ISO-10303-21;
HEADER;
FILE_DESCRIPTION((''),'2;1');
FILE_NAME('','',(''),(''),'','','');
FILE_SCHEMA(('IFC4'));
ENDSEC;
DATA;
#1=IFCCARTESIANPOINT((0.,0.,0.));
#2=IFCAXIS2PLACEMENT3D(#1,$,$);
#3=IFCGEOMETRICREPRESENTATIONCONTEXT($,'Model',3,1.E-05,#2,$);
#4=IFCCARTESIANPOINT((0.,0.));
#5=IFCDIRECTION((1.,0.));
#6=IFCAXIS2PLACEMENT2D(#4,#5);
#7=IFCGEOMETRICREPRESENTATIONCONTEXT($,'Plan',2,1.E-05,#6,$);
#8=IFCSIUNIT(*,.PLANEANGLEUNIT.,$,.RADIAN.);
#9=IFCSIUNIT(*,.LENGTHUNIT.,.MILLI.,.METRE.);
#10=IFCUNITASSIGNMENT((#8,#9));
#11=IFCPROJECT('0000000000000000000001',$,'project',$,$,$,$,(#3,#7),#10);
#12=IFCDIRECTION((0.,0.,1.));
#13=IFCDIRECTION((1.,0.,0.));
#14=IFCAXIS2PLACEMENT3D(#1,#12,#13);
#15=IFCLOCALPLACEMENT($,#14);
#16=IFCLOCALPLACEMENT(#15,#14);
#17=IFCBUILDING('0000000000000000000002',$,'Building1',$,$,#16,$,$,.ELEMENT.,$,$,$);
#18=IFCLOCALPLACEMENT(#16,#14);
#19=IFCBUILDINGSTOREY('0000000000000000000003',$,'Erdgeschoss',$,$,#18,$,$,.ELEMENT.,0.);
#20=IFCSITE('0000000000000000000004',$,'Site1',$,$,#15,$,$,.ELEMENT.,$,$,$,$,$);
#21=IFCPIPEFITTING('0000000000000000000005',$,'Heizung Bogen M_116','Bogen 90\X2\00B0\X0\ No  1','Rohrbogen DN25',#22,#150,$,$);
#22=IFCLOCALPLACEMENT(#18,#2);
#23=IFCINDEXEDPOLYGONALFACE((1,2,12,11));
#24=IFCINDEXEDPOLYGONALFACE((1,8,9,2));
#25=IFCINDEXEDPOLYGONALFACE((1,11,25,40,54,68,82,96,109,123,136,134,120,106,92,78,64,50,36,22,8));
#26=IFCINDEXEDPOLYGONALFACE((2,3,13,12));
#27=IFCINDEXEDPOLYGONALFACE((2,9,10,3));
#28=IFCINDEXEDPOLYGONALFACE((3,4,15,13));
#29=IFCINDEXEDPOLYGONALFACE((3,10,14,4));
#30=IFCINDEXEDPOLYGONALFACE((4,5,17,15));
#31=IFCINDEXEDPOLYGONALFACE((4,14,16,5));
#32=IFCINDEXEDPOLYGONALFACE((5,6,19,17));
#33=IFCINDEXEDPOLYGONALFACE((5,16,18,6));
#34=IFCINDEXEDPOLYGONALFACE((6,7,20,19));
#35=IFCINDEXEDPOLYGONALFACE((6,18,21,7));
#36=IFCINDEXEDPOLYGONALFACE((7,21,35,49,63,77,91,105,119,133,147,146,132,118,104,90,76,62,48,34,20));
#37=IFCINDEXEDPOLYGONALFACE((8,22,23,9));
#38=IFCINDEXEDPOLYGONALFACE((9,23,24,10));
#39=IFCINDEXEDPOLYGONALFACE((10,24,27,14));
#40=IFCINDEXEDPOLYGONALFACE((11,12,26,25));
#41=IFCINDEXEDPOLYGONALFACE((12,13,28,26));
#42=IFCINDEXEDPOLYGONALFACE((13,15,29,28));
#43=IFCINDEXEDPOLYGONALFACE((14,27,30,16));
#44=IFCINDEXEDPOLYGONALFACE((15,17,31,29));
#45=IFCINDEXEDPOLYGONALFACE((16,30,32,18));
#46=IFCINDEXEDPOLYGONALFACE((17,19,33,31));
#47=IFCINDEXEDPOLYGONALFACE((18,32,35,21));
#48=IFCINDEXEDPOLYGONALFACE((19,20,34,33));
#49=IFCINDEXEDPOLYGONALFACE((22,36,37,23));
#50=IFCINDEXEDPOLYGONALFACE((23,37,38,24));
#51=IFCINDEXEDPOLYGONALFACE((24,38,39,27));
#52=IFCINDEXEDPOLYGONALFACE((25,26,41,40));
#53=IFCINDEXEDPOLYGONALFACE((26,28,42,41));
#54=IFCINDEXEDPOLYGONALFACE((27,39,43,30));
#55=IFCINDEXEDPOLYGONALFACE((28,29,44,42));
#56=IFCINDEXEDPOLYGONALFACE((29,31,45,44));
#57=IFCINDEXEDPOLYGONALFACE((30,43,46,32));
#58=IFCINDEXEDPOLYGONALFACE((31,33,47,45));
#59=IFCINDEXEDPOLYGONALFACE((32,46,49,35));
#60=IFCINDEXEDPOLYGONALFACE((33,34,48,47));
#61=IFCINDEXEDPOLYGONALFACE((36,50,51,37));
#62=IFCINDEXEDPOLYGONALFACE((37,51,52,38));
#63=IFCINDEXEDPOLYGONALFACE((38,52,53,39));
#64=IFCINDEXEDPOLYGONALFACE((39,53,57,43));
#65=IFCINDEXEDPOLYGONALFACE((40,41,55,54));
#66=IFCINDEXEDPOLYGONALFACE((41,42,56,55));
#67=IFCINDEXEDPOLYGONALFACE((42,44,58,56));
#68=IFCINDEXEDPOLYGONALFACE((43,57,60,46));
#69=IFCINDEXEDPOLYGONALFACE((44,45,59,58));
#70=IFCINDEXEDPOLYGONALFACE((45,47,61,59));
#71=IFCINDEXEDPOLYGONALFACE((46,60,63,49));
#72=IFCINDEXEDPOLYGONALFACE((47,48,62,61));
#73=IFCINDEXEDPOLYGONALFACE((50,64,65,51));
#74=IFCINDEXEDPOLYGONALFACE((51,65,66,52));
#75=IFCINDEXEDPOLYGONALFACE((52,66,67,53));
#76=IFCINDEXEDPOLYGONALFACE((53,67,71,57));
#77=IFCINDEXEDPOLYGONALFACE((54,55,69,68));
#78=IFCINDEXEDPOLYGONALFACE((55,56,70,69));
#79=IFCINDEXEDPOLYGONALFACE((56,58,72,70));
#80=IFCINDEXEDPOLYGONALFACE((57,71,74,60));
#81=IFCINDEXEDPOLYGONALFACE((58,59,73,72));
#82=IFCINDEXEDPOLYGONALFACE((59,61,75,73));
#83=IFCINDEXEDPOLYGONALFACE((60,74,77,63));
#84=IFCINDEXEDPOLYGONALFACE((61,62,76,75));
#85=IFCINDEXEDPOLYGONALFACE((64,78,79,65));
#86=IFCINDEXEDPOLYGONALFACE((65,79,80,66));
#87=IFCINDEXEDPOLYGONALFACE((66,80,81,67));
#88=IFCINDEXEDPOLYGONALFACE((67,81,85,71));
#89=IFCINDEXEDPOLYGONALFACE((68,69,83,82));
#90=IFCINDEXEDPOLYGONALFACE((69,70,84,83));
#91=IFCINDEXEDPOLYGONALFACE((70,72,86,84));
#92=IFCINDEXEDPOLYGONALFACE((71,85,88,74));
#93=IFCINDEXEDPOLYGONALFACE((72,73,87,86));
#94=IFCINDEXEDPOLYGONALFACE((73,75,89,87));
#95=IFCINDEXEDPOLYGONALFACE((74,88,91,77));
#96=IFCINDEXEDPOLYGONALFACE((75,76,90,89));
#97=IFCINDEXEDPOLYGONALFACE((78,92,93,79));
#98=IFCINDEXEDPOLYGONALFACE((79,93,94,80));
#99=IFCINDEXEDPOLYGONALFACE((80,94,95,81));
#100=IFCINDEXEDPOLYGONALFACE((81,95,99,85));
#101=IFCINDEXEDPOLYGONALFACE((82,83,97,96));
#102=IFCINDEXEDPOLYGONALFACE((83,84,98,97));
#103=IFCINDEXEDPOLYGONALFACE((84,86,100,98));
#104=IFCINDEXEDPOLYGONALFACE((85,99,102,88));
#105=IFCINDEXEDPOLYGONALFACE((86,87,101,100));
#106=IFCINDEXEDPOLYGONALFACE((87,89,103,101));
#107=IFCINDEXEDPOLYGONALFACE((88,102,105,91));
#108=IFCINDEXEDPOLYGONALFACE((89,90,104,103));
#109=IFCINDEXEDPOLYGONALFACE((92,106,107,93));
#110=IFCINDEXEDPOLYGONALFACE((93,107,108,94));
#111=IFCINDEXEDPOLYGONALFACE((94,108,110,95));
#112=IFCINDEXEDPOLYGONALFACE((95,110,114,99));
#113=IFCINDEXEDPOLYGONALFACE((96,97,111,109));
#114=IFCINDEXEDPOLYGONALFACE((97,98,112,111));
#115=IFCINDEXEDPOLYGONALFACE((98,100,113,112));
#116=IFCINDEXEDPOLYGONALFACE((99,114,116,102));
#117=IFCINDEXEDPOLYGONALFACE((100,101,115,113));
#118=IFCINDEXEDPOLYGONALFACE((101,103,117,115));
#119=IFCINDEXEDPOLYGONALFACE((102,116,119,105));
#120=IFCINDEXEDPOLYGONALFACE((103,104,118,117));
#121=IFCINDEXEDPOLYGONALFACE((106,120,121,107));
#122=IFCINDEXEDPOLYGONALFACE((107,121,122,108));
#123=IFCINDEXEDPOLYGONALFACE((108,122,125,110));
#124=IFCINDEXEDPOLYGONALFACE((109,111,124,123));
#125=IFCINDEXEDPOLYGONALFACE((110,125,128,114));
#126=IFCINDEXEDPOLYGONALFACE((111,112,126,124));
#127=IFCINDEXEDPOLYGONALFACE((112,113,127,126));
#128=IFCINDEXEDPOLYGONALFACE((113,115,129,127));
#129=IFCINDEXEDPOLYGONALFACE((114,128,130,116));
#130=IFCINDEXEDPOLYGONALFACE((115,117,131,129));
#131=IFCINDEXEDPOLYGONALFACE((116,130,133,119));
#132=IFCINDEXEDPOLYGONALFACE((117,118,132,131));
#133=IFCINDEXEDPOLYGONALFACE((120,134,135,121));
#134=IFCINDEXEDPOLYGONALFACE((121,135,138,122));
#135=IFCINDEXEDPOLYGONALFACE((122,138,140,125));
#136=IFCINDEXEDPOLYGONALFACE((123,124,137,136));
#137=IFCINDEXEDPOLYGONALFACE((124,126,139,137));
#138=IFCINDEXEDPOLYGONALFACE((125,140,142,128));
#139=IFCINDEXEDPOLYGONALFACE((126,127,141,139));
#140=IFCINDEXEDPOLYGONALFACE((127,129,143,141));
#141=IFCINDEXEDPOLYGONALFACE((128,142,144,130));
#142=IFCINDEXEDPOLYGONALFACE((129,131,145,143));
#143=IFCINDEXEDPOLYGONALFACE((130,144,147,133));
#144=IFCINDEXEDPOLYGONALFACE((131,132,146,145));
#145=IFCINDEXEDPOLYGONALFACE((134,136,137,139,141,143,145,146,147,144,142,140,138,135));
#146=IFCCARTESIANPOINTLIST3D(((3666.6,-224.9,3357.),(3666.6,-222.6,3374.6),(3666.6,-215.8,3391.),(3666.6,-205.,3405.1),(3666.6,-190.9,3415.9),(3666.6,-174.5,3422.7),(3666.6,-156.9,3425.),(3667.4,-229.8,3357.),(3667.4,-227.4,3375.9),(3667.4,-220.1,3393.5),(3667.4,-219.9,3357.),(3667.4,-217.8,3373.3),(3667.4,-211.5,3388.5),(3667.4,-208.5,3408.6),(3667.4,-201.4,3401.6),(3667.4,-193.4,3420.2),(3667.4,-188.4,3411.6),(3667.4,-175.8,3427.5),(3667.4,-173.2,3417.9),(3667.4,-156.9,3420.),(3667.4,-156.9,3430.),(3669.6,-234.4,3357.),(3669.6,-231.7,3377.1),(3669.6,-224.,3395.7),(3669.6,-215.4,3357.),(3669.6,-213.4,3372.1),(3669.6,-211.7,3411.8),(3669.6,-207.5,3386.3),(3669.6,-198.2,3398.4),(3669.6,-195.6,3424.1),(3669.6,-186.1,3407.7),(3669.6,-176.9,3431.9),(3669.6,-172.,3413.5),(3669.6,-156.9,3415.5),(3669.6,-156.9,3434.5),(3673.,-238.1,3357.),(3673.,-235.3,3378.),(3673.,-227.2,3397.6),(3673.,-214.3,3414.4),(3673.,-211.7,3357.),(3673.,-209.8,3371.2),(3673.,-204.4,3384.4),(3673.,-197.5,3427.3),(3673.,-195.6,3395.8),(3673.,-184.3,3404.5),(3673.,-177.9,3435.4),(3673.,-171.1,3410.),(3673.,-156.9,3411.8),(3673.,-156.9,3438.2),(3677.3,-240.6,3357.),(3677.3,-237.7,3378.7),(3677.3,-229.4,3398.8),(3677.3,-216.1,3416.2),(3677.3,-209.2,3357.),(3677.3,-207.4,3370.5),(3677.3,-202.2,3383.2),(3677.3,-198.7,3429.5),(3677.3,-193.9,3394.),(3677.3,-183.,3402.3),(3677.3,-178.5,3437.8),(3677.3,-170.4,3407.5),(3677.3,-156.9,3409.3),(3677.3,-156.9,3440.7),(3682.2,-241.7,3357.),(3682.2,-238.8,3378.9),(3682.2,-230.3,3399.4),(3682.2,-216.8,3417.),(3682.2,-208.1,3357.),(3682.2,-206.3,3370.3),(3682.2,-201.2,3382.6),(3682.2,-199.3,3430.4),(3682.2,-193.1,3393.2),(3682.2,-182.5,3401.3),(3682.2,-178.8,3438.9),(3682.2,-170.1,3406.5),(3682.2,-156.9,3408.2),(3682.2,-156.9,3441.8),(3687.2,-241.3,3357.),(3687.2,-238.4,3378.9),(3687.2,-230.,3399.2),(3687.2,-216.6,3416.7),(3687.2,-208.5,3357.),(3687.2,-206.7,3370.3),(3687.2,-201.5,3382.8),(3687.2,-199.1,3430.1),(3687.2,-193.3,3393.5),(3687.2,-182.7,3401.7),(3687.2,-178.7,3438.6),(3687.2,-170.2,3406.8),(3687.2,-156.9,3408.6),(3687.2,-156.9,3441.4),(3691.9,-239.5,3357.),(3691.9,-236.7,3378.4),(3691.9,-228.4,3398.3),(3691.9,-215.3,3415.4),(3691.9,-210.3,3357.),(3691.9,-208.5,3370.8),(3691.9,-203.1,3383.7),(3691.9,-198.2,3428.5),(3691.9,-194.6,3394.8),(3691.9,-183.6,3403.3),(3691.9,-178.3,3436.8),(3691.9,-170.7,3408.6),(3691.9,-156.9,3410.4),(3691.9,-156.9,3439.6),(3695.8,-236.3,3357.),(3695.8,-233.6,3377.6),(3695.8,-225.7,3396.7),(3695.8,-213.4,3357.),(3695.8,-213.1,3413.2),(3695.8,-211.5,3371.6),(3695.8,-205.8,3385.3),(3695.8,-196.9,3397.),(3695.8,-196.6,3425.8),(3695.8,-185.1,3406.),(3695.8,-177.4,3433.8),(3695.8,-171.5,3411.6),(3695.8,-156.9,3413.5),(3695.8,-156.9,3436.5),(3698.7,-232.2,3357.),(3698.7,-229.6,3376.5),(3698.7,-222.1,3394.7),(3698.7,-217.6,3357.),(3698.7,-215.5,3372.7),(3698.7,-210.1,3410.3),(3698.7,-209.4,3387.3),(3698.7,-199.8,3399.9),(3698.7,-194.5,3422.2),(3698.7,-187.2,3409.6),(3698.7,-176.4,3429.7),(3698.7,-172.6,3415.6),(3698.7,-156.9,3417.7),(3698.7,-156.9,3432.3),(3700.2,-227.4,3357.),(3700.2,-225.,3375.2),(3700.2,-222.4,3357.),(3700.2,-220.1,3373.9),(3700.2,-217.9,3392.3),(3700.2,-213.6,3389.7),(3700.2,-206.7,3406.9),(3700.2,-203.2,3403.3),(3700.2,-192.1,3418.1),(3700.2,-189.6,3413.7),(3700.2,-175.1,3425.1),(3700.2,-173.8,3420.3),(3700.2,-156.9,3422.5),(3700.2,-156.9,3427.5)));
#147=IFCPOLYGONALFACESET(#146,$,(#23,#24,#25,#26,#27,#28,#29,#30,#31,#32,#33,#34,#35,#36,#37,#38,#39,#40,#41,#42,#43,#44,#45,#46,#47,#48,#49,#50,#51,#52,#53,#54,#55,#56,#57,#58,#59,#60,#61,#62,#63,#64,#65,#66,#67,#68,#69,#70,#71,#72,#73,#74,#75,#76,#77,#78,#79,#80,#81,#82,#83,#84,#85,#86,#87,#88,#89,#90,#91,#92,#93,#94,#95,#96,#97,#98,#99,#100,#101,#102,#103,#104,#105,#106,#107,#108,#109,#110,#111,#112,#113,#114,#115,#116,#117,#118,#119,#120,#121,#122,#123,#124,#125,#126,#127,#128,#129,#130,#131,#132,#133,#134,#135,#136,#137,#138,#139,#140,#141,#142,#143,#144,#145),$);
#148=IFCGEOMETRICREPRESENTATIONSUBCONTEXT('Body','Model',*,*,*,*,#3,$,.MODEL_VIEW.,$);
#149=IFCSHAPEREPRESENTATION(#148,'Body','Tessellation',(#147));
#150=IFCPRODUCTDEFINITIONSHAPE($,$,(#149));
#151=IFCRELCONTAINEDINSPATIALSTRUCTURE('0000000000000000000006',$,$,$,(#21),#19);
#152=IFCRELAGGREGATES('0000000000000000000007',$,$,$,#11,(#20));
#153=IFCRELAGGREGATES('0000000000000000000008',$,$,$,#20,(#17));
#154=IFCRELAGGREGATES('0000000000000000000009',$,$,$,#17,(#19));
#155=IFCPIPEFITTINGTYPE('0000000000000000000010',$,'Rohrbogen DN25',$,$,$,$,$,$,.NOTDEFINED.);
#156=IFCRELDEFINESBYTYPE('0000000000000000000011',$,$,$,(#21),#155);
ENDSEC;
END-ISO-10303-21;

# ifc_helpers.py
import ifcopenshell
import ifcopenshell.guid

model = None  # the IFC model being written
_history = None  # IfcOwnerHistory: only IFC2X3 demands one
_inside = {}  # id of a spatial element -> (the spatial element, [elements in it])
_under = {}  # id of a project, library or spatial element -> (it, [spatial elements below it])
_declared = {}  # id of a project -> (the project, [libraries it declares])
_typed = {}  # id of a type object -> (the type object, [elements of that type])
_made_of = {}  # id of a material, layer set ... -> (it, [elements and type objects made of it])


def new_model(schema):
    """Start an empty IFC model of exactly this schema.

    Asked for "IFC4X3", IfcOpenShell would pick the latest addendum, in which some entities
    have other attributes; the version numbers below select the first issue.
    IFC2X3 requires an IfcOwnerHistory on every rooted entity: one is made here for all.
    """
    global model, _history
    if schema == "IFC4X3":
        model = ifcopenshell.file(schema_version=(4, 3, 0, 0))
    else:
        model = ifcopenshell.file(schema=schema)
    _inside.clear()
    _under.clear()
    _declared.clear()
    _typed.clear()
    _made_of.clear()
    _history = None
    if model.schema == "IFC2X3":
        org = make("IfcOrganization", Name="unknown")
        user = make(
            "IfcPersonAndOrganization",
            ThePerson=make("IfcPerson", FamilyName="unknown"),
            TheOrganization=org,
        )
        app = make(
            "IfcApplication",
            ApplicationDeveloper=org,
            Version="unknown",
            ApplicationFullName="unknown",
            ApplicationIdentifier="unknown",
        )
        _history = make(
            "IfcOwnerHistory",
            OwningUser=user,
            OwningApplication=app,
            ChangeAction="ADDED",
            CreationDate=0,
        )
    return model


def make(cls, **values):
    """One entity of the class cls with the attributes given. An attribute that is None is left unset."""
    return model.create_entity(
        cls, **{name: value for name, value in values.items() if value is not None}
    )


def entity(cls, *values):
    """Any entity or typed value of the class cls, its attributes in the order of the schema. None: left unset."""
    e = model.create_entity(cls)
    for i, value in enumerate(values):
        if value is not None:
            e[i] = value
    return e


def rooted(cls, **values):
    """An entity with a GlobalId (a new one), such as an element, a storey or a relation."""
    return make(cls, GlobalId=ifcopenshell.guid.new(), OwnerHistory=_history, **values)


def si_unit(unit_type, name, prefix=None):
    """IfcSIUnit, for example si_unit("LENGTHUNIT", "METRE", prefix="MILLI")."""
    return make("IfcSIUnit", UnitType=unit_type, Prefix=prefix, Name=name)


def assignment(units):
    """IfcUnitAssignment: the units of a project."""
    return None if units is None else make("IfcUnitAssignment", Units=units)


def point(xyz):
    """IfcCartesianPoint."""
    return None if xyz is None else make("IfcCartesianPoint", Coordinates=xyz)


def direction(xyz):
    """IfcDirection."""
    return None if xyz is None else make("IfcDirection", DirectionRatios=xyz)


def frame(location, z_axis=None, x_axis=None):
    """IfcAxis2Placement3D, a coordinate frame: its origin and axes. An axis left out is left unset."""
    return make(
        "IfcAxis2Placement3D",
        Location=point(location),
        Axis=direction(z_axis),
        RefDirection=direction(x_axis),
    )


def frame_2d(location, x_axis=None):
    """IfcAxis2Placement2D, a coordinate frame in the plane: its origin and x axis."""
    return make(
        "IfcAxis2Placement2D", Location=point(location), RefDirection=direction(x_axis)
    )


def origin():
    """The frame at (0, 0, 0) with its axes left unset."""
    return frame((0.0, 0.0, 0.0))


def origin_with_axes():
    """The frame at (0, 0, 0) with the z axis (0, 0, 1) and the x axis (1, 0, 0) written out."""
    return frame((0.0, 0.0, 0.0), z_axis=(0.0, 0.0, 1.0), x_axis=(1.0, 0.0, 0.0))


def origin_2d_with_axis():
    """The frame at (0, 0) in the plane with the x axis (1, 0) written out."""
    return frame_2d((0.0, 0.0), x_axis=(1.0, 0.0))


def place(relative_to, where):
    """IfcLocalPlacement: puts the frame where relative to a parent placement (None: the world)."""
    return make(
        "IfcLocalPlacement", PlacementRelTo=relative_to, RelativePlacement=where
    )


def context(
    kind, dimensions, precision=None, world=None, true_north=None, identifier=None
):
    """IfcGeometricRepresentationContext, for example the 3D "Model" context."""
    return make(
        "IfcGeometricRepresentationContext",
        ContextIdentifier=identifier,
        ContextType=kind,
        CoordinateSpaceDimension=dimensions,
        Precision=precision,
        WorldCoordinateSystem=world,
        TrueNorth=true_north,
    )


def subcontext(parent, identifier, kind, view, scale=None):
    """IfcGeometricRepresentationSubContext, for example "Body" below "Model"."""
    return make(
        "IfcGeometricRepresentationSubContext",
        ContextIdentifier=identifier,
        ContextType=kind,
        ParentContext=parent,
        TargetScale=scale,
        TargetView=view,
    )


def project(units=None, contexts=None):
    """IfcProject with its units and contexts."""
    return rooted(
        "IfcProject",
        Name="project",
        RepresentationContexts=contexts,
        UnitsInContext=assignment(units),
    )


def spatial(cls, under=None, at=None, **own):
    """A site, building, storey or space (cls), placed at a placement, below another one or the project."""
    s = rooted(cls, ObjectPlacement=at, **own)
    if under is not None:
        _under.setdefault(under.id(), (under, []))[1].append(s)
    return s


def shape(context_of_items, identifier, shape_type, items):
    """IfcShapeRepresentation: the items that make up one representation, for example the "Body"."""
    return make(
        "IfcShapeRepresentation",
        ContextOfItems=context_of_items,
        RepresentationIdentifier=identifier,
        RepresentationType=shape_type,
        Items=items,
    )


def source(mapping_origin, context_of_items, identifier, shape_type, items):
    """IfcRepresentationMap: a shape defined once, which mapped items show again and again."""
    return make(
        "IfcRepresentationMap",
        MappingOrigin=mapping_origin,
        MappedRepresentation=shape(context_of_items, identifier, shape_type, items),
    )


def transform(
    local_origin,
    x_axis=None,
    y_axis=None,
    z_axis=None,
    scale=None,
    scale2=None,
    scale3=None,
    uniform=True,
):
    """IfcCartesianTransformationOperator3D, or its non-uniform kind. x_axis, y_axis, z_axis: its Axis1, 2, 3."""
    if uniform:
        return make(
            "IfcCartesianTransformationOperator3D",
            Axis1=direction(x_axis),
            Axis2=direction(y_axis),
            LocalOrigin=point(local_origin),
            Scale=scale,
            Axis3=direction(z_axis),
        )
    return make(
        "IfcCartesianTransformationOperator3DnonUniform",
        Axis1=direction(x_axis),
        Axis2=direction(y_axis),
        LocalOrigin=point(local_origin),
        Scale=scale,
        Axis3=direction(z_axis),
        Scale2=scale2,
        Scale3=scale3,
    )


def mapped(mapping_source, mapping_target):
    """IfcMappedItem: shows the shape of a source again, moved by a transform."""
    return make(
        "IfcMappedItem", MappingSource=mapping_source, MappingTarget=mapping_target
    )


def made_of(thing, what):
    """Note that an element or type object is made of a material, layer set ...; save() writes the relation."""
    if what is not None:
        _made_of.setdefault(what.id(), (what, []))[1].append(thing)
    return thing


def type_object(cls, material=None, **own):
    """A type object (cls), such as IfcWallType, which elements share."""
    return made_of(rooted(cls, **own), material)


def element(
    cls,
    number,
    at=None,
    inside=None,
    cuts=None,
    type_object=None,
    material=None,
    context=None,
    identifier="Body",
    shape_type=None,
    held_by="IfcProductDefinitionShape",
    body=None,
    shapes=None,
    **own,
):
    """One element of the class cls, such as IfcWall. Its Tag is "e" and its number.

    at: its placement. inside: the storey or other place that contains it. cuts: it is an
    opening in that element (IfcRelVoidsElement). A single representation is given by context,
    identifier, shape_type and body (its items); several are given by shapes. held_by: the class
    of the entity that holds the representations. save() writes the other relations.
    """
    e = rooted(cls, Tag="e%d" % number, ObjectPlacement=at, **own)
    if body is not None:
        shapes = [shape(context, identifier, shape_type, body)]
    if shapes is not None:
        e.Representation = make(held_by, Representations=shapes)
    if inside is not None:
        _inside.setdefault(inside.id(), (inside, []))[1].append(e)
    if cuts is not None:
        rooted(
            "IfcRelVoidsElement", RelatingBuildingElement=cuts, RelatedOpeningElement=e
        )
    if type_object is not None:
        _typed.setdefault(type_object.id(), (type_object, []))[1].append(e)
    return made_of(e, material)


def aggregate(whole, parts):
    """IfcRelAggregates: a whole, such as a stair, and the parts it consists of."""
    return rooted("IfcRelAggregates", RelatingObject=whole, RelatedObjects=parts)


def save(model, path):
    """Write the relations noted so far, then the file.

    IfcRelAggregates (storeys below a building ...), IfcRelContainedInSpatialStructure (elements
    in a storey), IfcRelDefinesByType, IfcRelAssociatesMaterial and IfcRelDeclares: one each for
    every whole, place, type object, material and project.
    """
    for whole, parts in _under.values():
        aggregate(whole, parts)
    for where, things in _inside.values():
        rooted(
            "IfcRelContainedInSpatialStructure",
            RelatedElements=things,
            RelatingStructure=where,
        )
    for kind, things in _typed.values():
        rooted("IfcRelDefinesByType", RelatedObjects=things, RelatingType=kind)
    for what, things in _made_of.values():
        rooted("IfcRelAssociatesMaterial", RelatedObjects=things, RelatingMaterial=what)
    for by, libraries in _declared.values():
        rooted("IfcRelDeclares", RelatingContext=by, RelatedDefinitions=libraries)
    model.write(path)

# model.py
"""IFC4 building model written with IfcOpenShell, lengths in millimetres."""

from ifc_helpers import new_model, entity, si_unit, frame, origin, origin_with_axes, origin_2d_with_axis, place, context, subcontext, project, spatial, source, transform, mapped, type_object, element, save


model = new_model("IFC4")

# Units and contexts
model_context = context("Model", 3, precision=1e-05, world=origin())
plan_context = context("Plan", 2, precision=1e-05, world=origin_2d_with_axis())
body_context = subcontext(model_context, "Body", "Model", "MODEL_VIEW")
ifc_project = project(units=[si_unit("PLANEANGLEUNIT", "RADIAN"), si_unit("LENGTHUNIT", "METRE", prefix="MILLI")], contexts=[model_context, plan_context])

# Site, building, storey
site_placement = place(None, origin_with_axes())
site = spatial("IfcSite", under=ifc_project, at=site_placement, Name="Site1", CompositionType="ELEMENT")
building_placement = place(site_placement, origin_with_axes())
building = spatial("IfcBuilding", under=site, at=building_placement, Name="Building1", CompositionType="ELEMENT")
storey_placement = place(building_placement, origin_with_axes())
storey = spatial("IfcBuildingStorey", under=building, at=storey_placement, Name="Erdgeschoss", CompositionType="ELEMENT", Elevation=0.0)

# Pipe fitting
pipe_fitting_type_1 = type_object("IfcPipeFittingType", Name="Rohrbogen DN25", PredefinedType="NOTDEFINED")
shared_shape_1 = source(origin_with_axes(), body_context, "Body", "SolidModel", [
    entity("IfcRevolvedAreaSolid", entity("IfcCircleProfileDef", "AREA", None, entity("IfcAxis2Placement2D", entity("IfcCartesianPoint", [0.0, 0.0]), entity("IfcDirection", [1.0, 0.0])), 16.9), entity("IfcAxis2Placement3D", entity("IfcCartesianPoint", [-42.4, 0.0, 25.6]), entity("IfcDirection", [1.0, 0.0, 0.0]), entity("IfcDirection", [0.0, -1.0, 0.0])), entity("IfcAxis1Placement", entity("IfcCartesianPoint", [0.0, 68.0, 0.0]), entity("IfcDirection", [-1.0, 0.0, 0.0])), 1.570796),
])
for number, where, z_axis, x_axis, name in (
    (1, (3683.5, -199.3, 3399.4), (0.0, 0.0, 1.0), (1.0, 0.0, 0.0), "Heizung Bogen M_116"),
):
    element("IfcPipeFitting", number, at=place(storey_placement, frame(where, z_axis=z_axis, x_axis=x_axis)), inside=storey, type_object=pipe_fitting_type_1, Name=name, Description="Bogen 90° No  1", ObjectType="Rohrbogen DN25", context=body_context, shape_type="MappedRepresentation", body=[
        mapped(shared_shape_1, transform((0.0, 0.0, 0.0), x_axis=(0.0, -1.0, 0.0), y_axis=(1.0, 0.0, 0.0), z_axis=(0.0, 0.0, 1.0), scale=1.0)),
    ])

save(model, "model.ifc")
